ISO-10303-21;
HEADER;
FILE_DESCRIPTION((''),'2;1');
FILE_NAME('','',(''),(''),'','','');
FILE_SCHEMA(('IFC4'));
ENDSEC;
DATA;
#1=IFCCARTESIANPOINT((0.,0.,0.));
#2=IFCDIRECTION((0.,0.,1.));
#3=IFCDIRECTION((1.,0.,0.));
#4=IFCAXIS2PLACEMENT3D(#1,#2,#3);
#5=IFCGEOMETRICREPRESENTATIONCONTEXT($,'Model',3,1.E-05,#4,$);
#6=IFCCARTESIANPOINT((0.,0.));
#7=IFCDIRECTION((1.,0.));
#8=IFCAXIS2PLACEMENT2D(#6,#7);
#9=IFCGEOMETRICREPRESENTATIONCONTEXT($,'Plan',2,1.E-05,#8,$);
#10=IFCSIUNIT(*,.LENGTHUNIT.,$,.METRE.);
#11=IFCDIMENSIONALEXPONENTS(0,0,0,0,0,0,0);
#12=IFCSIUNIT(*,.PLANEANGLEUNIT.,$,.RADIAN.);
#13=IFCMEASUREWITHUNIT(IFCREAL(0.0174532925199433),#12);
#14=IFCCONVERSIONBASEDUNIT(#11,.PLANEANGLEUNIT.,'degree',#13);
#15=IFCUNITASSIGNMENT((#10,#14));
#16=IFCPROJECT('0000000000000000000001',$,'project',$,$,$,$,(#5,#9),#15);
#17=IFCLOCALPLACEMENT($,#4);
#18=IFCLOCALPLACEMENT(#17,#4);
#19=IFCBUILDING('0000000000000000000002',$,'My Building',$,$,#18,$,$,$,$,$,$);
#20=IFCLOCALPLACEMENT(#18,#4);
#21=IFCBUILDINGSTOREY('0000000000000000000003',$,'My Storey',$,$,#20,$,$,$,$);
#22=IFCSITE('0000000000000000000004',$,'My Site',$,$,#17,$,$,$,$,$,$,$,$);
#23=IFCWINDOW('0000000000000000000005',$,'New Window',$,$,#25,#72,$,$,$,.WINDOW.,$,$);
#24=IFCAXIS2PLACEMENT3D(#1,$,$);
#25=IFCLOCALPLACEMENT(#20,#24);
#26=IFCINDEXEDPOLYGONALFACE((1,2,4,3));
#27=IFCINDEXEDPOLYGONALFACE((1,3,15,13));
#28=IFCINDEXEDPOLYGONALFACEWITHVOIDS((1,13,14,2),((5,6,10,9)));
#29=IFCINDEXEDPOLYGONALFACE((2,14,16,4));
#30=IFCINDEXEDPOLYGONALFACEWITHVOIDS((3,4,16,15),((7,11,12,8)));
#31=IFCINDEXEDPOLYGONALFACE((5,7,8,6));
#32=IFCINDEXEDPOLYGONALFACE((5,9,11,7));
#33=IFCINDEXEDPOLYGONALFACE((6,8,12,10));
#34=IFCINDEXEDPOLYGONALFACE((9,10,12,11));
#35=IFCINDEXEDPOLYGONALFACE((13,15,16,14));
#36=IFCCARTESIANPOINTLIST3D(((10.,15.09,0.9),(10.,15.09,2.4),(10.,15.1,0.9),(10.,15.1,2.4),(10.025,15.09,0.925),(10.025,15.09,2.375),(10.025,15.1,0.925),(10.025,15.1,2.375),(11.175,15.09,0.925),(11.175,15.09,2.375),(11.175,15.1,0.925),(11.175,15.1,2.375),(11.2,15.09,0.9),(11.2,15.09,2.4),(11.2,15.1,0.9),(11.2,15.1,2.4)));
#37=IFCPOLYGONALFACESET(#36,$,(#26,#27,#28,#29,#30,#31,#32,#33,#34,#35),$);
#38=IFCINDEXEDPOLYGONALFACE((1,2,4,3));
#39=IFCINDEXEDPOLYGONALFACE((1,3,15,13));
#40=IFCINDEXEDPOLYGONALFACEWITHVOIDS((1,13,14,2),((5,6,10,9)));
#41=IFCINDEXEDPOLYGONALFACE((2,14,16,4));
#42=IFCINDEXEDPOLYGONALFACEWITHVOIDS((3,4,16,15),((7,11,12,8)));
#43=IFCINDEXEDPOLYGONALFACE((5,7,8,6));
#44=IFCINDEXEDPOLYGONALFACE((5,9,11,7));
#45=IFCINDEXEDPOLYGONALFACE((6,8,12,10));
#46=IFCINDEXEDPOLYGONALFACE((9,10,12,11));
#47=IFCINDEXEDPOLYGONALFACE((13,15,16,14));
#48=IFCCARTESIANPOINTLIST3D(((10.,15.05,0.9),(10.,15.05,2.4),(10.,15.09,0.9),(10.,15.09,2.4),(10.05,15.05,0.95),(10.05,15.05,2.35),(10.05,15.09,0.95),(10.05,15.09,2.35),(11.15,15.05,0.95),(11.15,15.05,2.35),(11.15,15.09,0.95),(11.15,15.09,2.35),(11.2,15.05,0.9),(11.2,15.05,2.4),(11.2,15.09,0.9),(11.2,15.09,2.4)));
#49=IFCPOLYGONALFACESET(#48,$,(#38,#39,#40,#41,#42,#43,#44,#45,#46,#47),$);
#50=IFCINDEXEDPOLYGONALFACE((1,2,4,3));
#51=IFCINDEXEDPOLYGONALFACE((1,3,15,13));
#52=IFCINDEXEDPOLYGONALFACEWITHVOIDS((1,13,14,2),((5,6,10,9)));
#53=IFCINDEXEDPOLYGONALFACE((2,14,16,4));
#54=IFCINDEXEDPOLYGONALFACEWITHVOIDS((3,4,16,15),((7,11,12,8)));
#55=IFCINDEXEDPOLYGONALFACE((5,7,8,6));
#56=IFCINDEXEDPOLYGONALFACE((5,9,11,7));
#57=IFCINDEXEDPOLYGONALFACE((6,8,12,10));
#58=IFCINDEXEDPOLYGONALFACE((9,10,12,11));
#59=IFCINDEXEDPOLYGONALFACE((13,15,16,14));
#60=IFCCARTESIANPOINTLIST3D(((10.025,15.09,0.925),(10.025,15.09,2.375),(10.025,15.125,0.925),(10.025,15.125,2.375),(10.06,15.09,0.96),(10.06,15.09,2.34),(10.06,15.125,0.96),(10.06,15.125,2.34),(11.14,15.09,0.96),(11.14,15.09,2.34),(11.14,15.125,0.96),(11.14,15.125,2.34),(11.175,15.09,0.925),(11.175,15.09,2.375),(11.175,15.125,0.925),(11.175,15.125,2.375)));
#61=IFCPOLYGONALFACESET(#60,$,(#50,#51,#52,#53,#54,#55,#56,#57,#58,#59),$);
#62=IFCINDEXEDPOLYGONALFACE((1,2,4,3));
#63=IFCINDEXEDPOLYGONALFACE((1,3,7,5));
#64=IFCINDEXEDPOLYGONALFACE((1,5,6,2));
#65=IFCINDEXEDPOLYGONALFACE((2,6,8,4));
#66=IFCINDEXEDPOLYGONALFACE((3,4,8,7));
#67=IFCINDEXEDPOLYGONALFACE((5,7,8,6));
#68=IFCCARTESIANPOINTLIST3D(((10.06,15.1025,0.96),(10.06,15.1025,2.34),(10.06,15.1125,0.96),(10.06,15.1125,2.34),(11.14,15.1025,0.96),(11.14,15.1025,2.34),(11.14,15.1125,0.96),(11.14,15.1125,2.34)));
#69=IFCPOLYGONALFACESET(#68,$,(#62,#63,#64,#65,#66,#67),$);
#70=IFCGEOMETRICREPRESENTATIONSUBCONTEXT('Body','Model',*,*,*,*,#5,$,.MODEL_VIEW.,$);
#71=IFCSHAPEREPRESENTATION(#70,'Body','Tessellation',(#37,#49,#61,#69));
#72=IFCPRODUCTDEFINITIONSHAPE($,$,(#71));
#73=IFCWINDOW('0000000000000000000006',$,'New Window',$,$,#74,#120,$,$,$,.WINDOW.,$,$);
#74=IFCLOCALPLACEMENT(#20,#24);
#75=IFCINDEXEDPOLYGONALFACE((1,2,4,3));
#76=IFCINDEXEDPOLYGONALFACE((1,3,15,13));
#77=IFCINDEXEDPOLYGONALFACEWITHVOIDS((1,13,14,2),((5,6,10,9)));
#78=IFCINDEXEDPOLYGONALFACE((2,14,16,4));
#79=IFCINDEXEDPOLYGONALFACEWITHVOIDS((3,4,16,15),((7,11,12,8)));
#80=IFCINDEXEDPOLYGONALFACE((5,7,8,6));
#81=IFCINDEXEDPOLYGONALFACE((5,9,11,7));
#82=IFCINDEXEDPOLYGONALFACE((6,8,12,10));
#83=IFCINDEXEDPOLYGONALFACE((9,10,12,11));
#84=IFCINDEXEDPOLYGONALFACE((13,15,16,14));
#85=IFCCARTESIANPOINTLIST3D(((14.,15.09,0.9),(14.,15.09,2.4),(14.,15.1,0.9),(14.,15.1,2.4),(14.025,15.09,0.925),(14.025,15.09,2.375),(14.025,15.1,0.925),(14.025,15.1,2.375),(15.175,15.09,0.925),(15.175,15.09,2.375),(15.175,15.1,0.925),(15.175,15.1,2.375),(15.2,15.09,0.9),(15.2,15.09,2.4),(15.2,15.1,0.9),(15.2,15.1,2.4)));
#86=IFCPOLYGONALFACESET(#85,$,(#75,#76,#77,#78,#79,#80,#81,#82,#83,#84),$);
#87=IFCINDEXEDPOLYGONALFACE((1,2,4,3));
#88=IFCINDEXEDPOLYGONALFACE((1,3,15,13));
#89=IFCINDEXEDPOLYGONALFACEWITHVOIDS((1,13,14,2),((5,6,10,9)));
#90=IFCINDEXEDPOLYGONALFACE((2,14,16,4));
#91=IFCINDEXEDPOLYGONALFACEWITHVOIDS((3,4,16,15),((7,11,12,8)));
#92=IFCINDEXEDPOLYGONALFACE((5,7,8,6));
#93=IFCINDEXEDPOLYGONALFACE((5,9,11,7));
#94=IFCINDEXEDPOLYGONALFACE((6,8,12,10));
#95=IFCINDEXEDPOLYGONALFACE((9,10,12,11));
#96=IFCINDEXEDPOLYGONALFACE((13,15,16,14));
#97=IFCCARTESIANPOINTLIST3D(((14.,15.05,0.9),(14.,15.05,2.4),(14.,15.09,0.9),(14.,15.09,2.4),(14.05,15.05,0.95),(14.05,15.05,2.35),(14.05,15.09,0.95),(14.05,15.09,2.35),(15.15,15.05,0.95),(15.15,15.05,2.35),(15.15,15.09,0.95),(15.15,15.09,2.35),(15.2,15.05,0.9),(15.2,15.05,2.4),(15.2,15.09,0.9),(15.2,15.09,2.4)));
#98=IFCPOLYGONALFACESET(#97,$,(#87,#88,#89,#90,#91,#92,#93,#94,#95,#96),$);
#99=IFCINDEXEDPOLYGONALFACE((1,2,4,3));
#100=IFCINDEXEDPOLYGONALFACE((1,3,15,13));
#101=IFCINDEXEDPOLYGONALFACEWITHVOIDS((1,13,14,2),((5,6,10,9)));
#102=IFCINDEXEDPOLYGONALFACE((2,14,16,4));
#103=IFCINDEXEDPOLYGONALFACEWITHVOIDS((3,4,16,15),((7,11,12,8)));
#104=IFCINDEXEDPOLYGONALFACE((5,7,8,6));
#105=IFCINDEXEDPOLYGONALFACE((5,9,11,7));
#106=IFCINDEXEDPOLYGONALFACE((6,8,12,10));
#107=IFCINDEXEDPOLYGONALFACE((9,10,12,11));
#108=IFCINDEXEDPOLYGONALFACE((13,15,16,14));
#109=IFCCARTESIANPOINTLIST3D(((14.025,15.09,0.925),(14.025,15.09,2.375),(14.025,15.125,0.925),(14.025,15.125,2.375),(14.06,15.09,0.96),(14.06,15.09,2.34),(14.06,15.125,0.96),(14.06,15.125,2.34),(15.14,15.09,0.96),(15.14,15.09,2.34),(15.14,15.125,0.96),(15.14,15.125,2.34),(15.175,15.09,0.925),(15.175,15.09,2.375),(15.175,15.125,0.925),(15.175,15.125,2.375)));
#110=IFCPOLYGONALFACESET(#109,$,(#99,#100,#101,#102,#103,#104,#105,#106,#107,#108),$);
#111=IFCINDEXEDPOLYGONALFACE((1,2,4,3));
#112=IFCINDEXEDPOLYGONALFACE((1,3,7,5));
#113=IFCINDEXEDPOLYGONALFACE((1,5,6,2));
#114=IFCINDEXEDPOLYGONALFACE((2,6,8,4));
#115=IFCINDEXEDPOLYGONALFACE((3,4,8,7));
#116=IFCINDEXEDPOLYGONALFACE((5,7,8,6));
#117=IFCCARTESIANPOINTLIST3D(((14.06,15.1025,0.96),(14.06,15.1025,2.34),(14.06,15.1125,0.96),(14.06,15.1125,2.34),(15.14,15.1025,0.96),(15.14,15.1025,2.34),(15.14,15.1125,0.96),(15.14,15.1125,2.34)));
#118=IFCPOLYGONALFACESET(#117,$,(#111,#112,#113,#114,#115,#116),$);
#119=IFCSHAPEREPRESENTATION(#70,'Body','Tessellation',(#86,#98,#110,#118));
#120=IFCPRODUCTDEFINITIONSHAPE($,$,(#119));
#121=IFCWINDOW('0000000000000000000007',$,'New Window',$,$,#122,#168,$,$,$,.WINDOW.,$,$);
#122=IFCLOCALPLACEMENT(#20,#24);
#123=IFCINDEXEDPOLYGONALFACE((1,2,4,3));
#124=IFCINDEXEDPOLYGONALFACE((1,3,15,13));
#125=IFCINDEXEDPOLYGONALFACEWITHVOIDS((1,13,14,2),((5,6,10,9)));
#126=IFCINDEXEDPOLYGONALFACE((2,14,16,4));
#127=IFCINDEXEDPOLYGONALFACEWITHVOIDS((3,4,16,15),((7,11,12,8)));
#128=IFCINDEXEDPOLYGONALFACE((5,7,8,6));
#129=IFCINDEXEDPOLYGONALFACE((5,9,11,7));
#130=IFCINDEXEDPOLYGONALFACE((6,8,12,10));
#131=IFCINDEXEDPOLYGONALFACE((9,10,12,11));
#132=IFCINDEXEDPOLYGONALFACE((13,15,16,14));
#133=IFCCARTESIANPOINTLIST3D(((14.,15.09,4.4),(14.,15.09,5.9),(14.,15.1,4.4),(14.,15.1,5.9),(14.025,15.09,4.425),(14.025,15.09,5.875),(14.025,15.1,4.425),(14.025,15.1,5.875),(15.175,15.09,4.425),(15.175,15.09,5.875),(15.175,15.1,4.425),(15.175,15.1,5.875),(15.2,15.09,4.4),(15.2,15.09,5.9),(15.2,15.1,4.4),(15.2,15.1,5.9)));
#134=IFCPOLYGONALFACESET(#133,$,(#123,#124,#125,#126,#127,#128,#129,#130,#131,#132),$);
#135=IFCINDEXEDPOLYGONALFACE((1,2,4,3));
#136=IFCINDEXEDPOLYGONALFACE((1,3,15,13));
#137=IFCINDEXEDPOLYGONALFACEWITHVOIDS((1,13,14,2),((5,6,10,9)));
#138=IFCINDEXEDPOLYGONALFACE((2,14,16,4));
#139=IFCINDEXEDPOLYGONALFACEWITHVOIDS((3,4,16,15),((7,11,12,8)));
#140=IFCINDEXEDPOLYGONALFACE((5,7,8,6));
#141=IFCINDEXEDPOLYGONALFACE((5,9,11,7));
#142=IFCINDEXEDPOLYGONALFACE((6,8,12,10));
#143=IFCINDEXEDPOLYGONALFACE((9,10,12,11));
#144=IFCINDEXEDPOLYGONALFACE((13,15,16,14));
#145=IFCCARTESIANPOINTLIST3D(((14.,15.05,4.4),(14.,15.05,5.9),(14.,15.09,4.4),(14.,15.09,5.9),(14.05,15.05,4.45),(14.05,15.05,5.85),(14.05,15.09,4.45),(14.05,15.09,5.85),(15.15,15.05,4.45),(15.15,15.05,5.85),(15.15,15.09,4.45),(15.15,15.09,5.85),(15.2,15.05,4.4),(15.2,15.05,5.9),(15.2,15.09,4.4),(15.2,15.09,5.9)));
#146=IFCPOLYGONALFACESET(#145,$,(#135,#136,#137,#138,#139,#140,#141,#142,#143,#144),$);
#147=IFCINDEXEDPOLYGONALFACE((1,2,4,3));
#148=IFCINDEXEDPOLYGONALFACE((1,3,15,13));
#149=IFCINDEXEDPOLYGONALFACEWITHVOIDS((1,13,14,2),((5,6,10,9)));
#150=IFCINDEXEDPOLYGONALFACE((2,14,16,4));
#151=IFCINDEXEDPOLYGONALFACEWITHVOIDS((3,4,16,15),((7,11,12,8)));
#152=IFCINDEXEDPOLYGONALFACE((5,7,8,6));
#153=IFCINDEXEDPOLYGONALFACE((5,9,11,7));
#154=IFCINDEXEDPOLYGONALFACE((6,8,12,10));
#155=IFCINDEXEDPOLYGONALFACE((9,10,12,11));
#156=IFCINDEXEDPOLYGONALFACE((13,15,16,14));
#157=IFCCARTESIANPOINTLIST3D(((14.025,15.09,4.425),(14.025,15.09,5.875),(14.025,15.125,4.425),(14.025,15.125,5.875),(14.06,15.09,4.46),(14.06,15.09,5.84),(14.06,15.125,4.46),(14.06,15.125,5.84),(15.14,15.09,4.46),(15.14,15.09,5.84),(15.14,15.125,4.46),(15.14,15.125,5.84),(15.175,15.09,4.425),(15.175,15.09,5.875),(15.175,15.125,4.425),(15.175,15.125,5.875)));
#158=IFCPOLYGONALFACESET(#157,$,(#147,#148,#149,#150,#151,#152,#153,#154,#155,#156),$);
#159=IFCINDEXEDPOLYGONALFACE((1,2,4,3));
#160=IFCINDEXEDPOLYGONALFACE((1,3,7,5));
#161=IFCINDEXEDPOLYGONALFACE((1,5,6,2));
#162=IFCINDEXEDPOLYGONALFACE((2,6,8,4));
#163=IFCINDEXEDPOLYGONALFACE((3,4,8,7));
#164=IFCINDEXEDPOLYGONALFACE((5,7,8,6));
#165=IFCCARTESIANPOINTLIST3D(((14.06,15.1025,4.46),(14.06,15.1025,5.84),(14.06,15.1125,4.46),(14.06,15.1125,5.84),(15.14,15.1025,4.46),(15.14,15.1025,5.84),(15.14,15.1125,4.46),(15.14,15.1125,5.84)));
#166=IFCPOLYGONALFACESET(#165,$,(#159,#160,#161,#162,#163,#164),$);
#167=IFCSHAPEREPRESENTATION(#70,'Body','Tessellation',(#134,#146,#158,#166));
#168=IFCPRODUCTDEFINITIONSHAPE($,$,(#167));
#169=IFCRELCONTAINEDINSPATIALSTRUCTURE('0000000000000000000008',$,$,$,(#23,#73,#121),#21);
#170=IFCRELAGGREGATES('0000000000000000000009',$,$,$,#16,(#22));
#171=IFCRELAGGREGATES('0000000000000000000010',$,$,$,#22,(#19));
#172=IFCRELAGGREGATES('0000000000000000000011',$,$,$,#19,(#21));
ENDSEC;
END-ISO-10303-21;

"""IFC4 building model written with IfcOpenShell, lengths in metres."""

from ifc_helpers import new_model, entity, si_unit, converted_unit, frame, origin_with_axes, origin_2d_with_axis, place, context, subcontext, project, spatial, line, indexed_curve, outline, extrude, element, save


model = new_model("IFC4")

# Units and contexts
model_context = context("Model", 3, precision=1e-05, world=origin_with_axes())
plan_context = context("Plan", 2, precision=1e-05, world=origin_2d_with_axis())
body_context = subcontext(model_context, "Body", "Model", "MODEL_VIEW")
ifc_project = project(units=[si_unit("LENGTHUNIT", "METRE"), converted_unit("PLANEANGLEUNIT", "degree", entity("IfcReal", 0.0174532925199433), si_unit("PLANEANGLEUNIT", "RADIAN"), dimensions=[0, 0, 0, 0, 0, 0, 0])], contexts=[model_context, plan_context])

# Site, building, storey
site_placement = place(None, origin_with_axes())
site = spatial("IfcSite", under=ifc_project, at=site_placement, Name="My Site")
building_placement = place(site_placement, origin_with_axes())
building = spatial("IfcBuilding", under=site, at=building_placement, Name="My Building")
storey_placement = place(building_placement, origin_with_axes())
storey = spatial("IfcBuildingStorey", under=building, at=storey_placement, Name="My Storey")

# Window
for number, where, z_axis, x_axis, name in (
    (1, (10.0, 15.0, 0.9), (0.0, 0.0, 1.0), (1.0, 0.0, 0.0), "New Window"),
):
    element("IfcWindow", number, at=place(storey_placement, frame(where, z_axis=z_axis, x_axis=x_axis)), inside=storey, Name=name, PredefinedType="WINDOW", context=body_context, shape_type="SweptSolid", body=[
        extrude(outline(indexed_curve([(0.0, 0.0), (1.2, 0.0), (1.2, 1.5), (0.0, 1.5)], segments=[line(1, 2, 3, 4, 1)]), holes=[indexed_curve([(0.025, 0.025), (1.175, 0.025), (1.175, 1.475), (0.025, 1.475)], segments=[line(1, 2, 3, 4, 1)])]), frame((0.0, 0.09, 0.0), z_axis=(0.0, -1.0, 0.0), x_axis=(1.0, 0.0, 0.0)), (0.0, 0.0, -1.0), 0.01),
        extrude(outline(indexed_curve([(0.0, 0.0), (1.2, 0.0), (1.2, 1.5), (0.0, 1.5)], segments=[line(1, 2, 3, 4, 1)]), holes=[indexed_curve([(0.05, 0.05), (1.15, 0.05), (1.15, 1.45), (0.05, 1.45)], segments=[line(1, 2, 3, 4, 1)])]), frame((0.0, 0.05, 0.0), z_axis=(0.0, -1.0, 0.0), x_axis=(1.0, 0.0, 0.0)), (0.0, 0.0, -1.0), 0.04),
        extrude(outline(indexed_curve([(0.0, 0.0), (1.15, 0.0), (1.15, 1.45), (0.0, 1.45)], segments=[line(1, 2, 3, 4, 1)]), holes=[indexed_curve([(0.035, 0.035), (1.115, 0.035), (1.115, 1.415), (0.035, 1.415)], segments=[line(1, 2, 3, 4, 1)])]), frame((0.025, 0.09, 0.025), z_axis=(0.0, -1.0, 0.0), x_axis=(1.0, 0.0, 0.0)), (0.0, 0.0, -1.0), 0.035),
        extrude(outline(indexed_curve([(0.035, 0.035), (1.115, 0.035), (1.115, 1.415), (0.035, 1.415)], segments=[line(1, 2, 3, 4, 1)])), frame((0.025, 0.1025, 0.025), z_axis=(0.0, -1.0, 0.0), x_axis=(1.0, 0.0, 0.0)), (0.0, 0.0, -1.0), 0.01),
    ])

# Windows
for number, where, z_axis, x_axis, name in (
    (2, (14.0, 15.0, 0.9), (0.0, 0.0, 1.0), (1.0, 0.0, 0.0), "New Window"),
    (3, (14.0, 15.0, 4.4), (0.0, 0.0, 1.0), (1.0, 0.0, 0.0), "New Window"),
):
    element("IfcWindow", number, at=place(storey_placement, frame(where, z_axis=z_axis, x_axis=x_axis)), inside=storey, Name=name, PredefinedType="WINDOW", context=body_context, shape_type="SweptSolid", body=[
        extrude(outline(indexed_curve([(0.0, 0.0), (1.2, 0.0), (1.2, 1.5), (0.0, 1.5)], segments=[line(1, 2, 3, 4, 1)]), holes=[indexed_curve([(0.025, 0.025), (1.175, 0.025), (1.175, 1.475), (0.025, 1.475)], segments=[line(1, 2, 3, 4, 1)])]), frame((0.0, 0.09, 0.0), z_axis=(0.0, -1.0, 0.0), x_axis=(1.0, 0.0, 0.0)), (0.0, 0.0, -1.0), 0.01),
        extrude(outline(indexed_curve([(0.0, 0.0), (1.2, 0.0), (1.2, 1.5), (0.0, 1.5)], segments=[line(1, 2, 3, 4, 1)]), holes=[indexed_curve([(0.05, 0.05), (1.15, 0.05), (1.15, 1.45), (0.05, 1.45)], segments=[line(1, 2, 3, 4, 1)])]), frame((0.0, 0.05, 0.0), z_axis=(0.0, -1.0, 0.0), x_axis=(1.0, 0.0, 0.0)), (0.0, 0.0, -1.0), 0.04),
        extrude(outline(indexed_curve([(0.0, 0.0), (1.15, 0.0), (1.15, 1.45), (0.0, 1.45)], segments=[line(1, 2, 3, 4, 1)]), holes=[indexed_curve([(0.035, 0.035), (1.115, 0.035), (1.115, 1.415), (0.035, 1.415)], segments=[line(1, 2, 3, 4, 1)])]), frame((0.025, 0.09, 0.025), z_axis=(0.0, -1.0, 0.0), x_axis=(1.0, 0.0, 0.0)), (0.0, 0.0, -1.0), 0.035),
        extrude(outline(indexed_curve([(0.035, 0.035), (1.115, 0.035), (1.115, 1.415), (0.035, 1.415)], segments=[line(1, 2, 3, 4, 1)])), frame((0.025, 0.1025, 0.025), z_axis=(0.0, -1.0, 0.0), x_axis=(1.0, 0.0, 0.0)), (0.0, 0.0, -1.0), 0.01),
    ])

save(model, "model.ifc")
